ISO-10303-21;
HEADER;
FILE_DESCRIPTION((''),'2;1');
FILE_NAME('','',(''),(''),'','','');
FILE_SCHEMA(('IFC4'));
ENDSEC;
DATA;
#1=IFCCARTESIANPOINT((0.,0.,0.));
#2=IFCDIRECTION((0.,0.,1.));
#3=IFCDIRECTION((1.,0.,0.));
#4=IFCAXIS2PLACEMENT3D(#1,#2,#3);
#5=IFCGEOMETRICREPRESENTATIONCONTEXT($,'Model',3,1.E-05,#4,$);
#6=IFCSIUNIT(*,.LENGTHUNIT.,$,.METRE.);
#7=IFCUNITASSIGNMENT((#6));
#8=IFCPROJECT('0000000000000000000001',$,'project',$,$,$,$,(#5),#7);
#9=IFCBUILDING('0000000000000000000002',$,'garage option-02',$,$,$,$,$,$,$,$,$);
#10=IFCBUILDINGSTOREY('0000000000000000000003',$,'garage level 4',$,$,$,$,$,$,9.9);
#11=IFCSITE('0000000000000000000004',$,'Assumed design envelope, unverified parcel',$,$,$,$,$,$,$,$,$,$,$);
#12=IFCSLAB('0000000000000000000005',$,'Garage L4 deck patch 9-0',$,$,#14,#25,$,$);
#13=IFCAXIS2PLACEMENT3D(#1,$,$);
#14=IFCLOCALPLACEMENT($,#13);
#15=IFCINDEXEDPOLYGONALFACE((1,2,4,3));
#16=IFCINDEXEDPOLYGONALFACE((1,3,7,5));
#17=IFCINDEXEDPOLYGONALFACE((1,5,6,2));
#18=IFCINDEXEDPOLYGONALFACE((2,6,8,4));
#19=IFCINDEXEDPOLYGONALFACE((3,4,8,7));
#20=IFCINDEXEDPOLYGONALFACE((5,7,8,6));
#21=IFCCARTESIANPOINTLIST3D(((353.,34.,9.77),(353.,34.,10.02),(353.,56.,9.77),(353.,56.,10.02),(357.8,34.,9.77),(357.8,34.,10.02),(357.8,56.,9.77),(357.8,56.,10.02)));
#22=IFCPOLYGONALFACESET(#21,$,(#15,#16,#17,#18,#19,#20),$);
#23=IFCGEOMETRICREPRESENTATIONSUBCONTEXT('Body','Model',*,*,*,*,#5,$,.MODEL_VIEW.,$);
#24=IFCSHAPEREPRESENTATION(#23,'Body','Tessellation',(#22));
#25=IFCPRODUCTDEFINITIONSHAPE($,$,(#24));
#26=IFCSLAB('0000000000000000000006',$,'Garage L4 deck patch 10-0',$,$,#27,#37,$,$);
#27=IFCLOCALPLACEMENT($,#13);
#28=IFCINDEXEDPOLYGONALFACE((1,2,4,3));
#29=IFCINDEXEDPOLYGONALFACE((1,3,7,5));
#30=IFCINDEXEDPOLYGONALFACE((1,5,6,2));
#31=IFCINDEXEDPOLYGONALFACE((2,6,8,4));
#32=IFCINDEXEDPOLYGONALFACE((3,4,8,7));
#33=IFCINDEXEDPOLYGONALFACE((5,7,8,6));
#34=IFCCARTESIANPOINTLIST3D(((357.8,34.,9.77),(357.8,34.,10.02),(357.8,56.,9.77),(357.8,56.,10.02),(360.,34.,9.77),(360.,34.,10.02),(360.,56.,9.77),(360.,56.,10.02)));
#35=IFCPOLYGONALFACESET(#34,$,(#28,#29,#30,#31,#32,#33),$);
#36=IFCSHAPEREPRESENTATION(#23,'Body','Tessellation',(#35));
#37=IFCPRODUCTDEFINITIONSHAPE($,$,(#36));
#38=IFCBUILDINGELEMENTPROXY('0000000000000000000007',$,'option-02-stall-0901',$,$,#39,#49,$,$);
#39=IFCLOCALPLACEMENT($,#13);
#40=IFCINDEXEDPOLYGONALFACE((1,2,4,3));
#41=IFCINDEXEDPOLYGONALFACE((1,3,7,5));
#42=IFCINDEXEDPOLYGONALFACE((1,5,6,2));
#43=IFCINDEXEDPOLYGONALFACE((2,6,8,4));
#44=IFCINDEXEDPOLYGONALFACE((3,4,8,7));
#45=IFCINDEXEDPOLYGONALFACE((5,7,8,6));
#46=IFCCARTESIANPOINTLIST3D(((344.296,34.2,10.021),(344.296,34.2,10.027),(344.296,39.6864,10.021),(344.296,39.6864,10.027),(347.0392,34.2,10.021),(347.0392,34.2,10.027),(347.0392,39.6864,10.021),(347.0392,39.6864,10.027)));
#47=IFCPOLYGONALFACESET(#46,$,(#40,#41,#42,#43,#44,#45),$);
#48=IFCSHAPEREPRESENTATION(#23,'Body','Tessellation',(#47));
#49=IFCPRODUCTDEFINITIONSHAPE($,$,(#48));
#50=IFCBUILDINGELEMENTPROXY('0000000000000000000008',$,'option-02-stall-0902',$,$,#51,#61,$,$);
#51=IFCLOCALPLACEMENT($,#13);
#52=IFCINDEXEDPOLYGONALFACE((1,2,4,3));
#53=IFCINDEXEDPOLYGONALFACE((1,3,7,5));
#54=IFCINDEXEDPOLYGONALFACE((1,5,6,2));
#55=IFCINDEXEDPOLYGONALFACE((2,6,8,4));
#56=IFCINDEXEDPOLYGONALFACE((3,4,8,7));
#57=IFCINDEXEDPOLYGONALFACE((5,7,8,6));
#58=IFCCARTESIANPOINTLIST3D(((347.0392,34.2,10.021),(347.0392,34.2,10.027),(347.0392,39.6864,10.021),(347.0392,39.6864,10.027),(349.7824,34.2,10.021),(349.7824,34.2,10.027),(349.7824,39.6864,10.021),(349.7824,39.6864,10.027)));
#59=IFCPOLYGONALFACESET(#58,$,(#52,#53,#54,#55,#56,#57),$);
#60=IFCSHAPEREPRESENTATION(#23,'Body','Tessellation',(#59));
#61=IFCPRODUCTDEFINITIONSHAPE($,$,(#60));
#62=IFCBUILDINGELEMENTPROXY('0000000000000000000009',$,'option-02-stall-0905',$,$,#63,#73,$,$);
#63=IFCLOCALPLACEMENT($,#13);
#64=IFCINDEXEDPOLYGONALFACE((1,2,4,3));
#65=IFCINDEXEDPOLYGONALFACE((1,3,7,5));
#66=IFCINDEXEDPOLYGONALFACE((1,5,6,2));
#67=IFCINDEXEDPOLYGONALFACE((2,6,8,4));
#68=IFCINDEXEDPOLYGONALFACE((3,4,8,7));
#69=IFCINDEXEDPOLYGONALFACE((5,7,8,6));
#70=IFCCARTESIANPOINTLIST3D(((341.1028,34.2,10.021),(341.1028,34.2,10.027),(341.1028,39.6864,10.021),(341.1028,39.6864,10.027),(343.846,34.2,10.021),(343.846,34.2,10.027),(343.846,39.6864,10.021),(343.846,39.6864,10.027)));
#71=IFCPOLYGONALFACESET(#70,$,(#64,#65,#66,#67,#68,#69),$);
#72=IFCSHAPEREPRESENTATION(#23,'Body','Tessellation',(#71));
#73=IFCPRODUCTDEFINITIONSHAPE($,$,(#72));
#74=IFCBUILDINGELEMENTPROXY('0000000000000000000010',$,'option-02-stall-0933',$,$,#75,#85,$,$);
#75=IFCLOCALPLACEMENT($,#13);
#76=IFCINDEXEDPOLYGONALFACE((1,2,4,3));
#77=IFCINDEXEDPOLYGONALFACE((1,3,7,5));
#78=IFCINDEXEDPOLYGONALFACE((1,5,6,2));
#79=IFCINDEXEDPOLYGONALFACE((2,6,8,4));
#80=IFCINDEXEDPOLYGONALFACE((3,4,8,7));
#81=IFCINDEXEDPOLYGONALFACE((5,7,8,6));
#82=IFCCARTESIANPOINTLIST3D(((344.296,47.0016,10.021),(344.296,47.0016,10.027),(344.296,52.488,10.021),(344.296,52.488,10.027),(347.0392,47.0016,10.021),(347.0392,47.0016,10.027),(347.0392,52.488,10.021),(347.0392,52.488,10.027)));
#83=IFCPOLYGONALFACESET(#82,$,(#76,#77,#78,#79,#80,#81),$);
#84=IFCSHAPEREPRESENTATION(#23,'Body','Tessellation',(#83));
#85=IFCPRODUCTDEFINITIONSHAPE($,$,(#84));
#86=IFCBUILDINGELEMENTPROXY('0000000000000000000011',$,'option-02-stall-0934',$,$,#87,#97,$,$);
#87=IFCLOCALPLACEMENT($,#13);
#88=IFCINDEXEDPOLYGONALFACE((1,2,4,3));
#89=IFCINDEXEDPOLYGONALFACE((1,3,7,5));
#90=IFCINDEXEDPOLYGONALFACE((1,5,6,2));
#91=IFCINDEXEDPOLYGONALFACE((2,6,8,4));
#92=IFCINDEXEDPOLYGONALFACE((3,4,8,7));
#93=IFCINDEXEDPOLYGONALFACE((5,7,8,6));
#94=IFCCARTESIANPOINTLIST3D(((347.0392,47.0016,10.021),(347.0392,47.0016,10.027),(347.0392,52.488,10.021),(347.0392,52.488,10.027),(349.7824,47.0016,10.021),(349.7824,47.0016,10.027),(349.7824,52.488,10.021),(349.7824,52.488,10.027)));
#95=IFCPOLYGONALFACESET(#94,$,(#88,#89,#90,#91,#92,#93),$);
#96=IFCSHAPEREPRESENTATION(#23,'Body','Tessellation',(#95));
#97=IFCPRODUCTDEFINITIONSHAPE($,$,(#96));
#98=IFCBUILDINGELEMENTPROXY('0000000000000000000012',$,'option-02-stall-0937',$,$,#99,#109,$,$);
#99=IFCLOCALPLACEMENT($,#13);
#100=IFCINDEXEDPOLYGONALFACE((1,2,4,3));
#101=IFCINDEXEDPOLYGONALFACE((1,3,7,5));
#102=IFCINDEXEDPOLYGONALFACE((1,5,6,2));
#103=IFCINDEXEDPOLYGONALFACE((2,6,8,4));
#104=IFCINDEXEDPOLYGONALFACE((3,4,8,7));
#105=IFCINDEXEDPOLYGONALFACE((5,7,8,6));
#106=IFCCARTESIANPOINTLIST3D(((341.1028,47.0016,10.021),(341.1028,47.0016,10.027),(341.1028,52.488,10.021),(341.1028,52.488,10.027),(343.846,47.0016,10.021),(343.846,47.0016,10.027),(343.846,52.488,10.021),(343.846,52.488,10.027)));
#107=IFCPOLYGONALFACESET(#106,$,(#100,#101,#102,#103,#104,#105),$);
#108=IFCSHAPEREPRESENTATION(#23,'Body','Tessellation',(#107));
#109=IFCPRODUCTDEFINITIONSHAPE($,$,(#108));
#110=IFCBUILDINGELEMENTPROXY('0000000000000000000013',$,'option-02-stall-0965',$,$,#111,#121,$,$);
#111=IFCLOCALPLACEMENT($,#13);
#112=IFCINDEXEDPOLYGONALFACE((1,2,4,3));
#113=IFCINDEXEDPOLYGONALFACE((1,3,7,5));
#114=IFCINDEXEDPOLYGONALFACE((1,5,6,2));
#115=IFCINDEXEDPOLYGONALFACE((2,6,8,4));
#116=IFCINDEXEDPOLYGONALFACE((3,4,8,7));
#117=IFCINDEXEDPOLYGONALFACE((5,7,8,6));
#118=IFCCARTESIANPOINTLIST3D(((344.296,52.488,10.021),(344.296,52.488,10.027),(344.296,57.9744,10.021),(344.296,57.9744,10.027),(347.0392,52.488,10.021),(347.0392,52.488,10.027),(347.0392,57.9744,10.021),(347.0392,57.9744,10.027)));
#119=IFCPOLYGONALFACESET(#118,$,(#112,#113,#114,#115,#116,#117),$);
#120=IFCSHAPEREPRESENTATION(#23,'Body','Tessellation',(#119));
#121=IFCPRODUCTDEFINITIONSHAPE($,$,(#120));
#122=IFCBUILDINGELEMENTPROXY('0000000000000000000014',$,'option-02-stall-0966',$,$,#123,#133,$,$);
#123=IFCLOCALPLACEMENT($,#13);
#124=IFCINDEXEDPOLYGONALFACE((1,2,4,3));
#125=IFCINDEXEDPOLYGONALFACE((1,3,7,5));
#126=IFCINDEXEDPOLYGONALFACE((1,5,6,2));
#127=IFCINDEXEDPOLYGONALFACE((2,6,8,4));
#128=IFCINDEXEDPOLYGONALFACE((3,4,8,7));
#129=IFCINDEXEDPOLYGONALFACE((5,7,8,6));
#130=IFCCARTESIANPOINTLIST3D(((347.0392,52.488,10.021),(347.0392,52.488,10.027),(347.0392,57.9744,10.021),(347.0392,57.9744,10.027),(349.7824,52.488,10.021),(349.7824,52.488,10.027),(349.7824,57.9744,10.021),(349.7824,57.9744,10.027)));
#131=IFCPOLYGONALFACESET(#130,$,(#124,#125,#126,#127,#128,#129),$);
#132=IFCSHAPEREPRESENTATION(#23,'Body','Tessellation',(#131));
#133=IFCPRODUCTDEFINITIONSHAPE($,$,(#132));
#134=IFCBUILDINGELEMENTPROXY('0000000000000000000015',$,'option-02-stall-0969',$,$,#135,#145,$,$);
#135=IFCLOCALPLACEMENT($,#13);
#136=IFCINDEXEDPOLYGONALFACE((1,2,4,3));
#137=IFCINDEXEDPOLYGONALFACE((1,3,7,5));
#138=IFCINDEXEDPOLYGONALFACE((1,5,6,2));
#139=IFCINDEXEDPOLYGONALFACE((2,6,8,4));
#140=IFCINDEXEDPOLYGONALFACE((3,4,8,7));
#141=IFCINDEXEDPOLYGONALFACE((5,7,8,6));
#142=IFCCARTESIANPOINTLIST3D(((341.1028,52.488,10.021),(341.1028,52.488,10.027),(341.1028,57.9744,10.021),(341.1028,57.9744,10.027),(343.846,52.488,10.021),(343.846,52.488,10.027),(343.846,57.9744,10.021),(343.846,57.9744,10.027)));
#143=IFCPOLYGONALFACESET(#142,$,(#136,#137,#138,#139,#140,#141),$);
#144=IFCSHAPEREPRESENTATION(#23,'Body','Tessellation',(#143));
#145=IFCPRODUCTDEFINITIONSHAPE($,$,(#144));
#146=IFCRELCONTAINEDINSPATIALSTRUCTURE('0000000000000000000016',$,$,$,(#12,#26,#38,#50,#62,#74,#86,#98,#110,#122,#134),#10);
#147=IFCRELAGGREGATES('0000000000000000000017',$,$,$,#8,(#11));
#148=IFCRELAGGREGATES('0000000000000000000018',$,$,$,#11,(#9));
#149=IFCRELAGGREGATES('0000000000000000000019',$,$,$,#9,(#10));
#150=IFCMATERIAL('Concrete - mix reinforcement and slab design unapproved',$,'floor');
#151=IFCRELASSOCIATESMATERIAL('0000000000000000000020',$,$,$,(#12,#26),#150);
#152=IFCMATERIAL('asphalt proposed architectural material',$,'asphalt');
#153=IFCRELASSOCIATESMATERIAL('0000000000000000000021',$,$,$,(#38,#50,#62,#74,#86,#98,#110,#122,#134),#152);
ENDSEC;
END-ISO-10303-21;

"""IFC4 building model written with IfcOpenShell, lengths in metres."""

from ifc_helpers import new_model, si_unit, frame, origin_with_axes, place, context, subcontext, project, spatial, rectangle, extrude, material, element, save


model = new_model("IFC4")

# Units and contexts
model_context = context("Model", 3, precision=1e-05, world=origin_with_axes())
body_context = subcontext(model_context, "Body", "Model", "MODEL_VIEW")
ifc_project = project(units=[si_unit("LENGTHUNIT", "METRE")], contexts=[model_context])

# Site, building, storey
site = spatial("IfcSite", under=ifc_project, Name="Assumed design envelope, unverified parcel")
building = spatial("IfcBuilding", under=site, Name="garage option-02")
storey = spatial("IfcBuildingStorey", under=building, Name="garage level 4", Elevation=9.9)

# Shared definitions
ifc_material_1 = material(Name="Concrete - mix reinforcement and slab design unapproved", Category="floor")

# Slabs
slab_1_placement = place(None, frame((355.4, 45.0, 9.77), z_axis=(0.0, 0.0, 1.0), x_axis=(1.0, 0.0, 0.0)))
element("IfcSlab", 1, at=slab_1_placement, inside=storey, material=ifc_material_1, Name="Garage L4 deck patch 9-0", context=body_context, shape_type="SweptSolid", body=[
    extrude(rectangle(XDim=4.8, YDim=22.0), origin_with_axes(), (0.0, 0.0, 1.0), 0.25),
])
slab_2_placement = place(None, frame((358.9, 45.0, 9.77), z_axis=(0.0, 0.0, 1.0), x_axis=(1.0, 0.0, 0.0)))
element("IfcSlab", 2, at=slab_2_placement, inside=storey, material=ifc_material_1, Name="Garage L4 deck patch 10-0", context=body_context, shape_type="SweptSolid", body=[
    extrude(rectangle(XDim=2.2, YDim=22.0), origin_with_axes(), (0.0, 0.0, 1.0), 0.25),
])

# Building element proxies
ifc_material_2 = material(Name="asphalt proposed architectural material", Category="asphalt")
for number, where, z_axis, x_axis, name in (
    (3, (345.6676, 36.9432, 10.021), (0.0, 0.0, 1.0), (1.0, 0.0, 0.0), "option-02-stall-0901"),
    (4, (348.4108, 36.9432, 10.021), (0.0, 0.0, 1.0), (1.0, 0.0, 0.0), "option-02-stall-0902"),
    (5, (342.4744, 36.9432, 10.021), (0.0, 0.0, 1.0), (1.0, 0.0, 0.0), "option-02-stall-0905"),
    (6, (345.6676, 49.7448, 10.021), (0.0, 0.0, 1.0), (1.0, 0.0, 0.0), "option-02-stall-0933"),
    (7, (348.4108, 49.7448, 10.021), (0.0, 0.0, 1.0), (1.0, 0.0, 0.0), "option-02-stall-0934"),
    (8, (342.4744, 49.7448, 10.021), (0.0, 0.0, 1.0), (1.0, 0.0, 0.0), "option-02-stall-0937"),
):
    element("IfcBuildingElementProxy", number, at=place(None, frame(where, z_axis=z_axis, x_axis=x_axis)), inside=storey, material=ifc_material_2, Name=name, context=body_context, shape_type="SweptSolid", body=[
        extrude(rectangle(XDim=2.7432, YDim=5.4864), origin_with_axes(), (0.0, 0.0, 1.0), 0.006),
    ])
for number, where, z_axis, x_axis, name in (
    (9, (345.6676, 55.2312, 10.021), (0.0, 0.0, 1.0), (1.0, 0.0, 0.0), "option-02-stall-0965"),
    (10, (348.4108, 55.2312, 10.021), (0.0, 0.0, 1.0), (1.0, 0.0, 0.0), "option-02-stall-0966"),
    (11, (342.4744, 55.2312, 10.021), (0.0, 0.0, 1.0), (1.0, 0.0, 0.0), "option-02-stall-0969"),
):
    element("IfcBuildingElementProxy", number, at=place(None, frame(where, z_axis=z_axis, x_axis=x_axis)), inside=storey, material=ifc_material_2, Name=name, context=body_context, shape_type="SweptSolid", body=[
        extrude(rectangle(XDim=2.7432, YDim=5.4864), origin_with_axes(), (0.0, 0.0, 1.0), 0.006),
    ])

save(model, "model.ifc")
